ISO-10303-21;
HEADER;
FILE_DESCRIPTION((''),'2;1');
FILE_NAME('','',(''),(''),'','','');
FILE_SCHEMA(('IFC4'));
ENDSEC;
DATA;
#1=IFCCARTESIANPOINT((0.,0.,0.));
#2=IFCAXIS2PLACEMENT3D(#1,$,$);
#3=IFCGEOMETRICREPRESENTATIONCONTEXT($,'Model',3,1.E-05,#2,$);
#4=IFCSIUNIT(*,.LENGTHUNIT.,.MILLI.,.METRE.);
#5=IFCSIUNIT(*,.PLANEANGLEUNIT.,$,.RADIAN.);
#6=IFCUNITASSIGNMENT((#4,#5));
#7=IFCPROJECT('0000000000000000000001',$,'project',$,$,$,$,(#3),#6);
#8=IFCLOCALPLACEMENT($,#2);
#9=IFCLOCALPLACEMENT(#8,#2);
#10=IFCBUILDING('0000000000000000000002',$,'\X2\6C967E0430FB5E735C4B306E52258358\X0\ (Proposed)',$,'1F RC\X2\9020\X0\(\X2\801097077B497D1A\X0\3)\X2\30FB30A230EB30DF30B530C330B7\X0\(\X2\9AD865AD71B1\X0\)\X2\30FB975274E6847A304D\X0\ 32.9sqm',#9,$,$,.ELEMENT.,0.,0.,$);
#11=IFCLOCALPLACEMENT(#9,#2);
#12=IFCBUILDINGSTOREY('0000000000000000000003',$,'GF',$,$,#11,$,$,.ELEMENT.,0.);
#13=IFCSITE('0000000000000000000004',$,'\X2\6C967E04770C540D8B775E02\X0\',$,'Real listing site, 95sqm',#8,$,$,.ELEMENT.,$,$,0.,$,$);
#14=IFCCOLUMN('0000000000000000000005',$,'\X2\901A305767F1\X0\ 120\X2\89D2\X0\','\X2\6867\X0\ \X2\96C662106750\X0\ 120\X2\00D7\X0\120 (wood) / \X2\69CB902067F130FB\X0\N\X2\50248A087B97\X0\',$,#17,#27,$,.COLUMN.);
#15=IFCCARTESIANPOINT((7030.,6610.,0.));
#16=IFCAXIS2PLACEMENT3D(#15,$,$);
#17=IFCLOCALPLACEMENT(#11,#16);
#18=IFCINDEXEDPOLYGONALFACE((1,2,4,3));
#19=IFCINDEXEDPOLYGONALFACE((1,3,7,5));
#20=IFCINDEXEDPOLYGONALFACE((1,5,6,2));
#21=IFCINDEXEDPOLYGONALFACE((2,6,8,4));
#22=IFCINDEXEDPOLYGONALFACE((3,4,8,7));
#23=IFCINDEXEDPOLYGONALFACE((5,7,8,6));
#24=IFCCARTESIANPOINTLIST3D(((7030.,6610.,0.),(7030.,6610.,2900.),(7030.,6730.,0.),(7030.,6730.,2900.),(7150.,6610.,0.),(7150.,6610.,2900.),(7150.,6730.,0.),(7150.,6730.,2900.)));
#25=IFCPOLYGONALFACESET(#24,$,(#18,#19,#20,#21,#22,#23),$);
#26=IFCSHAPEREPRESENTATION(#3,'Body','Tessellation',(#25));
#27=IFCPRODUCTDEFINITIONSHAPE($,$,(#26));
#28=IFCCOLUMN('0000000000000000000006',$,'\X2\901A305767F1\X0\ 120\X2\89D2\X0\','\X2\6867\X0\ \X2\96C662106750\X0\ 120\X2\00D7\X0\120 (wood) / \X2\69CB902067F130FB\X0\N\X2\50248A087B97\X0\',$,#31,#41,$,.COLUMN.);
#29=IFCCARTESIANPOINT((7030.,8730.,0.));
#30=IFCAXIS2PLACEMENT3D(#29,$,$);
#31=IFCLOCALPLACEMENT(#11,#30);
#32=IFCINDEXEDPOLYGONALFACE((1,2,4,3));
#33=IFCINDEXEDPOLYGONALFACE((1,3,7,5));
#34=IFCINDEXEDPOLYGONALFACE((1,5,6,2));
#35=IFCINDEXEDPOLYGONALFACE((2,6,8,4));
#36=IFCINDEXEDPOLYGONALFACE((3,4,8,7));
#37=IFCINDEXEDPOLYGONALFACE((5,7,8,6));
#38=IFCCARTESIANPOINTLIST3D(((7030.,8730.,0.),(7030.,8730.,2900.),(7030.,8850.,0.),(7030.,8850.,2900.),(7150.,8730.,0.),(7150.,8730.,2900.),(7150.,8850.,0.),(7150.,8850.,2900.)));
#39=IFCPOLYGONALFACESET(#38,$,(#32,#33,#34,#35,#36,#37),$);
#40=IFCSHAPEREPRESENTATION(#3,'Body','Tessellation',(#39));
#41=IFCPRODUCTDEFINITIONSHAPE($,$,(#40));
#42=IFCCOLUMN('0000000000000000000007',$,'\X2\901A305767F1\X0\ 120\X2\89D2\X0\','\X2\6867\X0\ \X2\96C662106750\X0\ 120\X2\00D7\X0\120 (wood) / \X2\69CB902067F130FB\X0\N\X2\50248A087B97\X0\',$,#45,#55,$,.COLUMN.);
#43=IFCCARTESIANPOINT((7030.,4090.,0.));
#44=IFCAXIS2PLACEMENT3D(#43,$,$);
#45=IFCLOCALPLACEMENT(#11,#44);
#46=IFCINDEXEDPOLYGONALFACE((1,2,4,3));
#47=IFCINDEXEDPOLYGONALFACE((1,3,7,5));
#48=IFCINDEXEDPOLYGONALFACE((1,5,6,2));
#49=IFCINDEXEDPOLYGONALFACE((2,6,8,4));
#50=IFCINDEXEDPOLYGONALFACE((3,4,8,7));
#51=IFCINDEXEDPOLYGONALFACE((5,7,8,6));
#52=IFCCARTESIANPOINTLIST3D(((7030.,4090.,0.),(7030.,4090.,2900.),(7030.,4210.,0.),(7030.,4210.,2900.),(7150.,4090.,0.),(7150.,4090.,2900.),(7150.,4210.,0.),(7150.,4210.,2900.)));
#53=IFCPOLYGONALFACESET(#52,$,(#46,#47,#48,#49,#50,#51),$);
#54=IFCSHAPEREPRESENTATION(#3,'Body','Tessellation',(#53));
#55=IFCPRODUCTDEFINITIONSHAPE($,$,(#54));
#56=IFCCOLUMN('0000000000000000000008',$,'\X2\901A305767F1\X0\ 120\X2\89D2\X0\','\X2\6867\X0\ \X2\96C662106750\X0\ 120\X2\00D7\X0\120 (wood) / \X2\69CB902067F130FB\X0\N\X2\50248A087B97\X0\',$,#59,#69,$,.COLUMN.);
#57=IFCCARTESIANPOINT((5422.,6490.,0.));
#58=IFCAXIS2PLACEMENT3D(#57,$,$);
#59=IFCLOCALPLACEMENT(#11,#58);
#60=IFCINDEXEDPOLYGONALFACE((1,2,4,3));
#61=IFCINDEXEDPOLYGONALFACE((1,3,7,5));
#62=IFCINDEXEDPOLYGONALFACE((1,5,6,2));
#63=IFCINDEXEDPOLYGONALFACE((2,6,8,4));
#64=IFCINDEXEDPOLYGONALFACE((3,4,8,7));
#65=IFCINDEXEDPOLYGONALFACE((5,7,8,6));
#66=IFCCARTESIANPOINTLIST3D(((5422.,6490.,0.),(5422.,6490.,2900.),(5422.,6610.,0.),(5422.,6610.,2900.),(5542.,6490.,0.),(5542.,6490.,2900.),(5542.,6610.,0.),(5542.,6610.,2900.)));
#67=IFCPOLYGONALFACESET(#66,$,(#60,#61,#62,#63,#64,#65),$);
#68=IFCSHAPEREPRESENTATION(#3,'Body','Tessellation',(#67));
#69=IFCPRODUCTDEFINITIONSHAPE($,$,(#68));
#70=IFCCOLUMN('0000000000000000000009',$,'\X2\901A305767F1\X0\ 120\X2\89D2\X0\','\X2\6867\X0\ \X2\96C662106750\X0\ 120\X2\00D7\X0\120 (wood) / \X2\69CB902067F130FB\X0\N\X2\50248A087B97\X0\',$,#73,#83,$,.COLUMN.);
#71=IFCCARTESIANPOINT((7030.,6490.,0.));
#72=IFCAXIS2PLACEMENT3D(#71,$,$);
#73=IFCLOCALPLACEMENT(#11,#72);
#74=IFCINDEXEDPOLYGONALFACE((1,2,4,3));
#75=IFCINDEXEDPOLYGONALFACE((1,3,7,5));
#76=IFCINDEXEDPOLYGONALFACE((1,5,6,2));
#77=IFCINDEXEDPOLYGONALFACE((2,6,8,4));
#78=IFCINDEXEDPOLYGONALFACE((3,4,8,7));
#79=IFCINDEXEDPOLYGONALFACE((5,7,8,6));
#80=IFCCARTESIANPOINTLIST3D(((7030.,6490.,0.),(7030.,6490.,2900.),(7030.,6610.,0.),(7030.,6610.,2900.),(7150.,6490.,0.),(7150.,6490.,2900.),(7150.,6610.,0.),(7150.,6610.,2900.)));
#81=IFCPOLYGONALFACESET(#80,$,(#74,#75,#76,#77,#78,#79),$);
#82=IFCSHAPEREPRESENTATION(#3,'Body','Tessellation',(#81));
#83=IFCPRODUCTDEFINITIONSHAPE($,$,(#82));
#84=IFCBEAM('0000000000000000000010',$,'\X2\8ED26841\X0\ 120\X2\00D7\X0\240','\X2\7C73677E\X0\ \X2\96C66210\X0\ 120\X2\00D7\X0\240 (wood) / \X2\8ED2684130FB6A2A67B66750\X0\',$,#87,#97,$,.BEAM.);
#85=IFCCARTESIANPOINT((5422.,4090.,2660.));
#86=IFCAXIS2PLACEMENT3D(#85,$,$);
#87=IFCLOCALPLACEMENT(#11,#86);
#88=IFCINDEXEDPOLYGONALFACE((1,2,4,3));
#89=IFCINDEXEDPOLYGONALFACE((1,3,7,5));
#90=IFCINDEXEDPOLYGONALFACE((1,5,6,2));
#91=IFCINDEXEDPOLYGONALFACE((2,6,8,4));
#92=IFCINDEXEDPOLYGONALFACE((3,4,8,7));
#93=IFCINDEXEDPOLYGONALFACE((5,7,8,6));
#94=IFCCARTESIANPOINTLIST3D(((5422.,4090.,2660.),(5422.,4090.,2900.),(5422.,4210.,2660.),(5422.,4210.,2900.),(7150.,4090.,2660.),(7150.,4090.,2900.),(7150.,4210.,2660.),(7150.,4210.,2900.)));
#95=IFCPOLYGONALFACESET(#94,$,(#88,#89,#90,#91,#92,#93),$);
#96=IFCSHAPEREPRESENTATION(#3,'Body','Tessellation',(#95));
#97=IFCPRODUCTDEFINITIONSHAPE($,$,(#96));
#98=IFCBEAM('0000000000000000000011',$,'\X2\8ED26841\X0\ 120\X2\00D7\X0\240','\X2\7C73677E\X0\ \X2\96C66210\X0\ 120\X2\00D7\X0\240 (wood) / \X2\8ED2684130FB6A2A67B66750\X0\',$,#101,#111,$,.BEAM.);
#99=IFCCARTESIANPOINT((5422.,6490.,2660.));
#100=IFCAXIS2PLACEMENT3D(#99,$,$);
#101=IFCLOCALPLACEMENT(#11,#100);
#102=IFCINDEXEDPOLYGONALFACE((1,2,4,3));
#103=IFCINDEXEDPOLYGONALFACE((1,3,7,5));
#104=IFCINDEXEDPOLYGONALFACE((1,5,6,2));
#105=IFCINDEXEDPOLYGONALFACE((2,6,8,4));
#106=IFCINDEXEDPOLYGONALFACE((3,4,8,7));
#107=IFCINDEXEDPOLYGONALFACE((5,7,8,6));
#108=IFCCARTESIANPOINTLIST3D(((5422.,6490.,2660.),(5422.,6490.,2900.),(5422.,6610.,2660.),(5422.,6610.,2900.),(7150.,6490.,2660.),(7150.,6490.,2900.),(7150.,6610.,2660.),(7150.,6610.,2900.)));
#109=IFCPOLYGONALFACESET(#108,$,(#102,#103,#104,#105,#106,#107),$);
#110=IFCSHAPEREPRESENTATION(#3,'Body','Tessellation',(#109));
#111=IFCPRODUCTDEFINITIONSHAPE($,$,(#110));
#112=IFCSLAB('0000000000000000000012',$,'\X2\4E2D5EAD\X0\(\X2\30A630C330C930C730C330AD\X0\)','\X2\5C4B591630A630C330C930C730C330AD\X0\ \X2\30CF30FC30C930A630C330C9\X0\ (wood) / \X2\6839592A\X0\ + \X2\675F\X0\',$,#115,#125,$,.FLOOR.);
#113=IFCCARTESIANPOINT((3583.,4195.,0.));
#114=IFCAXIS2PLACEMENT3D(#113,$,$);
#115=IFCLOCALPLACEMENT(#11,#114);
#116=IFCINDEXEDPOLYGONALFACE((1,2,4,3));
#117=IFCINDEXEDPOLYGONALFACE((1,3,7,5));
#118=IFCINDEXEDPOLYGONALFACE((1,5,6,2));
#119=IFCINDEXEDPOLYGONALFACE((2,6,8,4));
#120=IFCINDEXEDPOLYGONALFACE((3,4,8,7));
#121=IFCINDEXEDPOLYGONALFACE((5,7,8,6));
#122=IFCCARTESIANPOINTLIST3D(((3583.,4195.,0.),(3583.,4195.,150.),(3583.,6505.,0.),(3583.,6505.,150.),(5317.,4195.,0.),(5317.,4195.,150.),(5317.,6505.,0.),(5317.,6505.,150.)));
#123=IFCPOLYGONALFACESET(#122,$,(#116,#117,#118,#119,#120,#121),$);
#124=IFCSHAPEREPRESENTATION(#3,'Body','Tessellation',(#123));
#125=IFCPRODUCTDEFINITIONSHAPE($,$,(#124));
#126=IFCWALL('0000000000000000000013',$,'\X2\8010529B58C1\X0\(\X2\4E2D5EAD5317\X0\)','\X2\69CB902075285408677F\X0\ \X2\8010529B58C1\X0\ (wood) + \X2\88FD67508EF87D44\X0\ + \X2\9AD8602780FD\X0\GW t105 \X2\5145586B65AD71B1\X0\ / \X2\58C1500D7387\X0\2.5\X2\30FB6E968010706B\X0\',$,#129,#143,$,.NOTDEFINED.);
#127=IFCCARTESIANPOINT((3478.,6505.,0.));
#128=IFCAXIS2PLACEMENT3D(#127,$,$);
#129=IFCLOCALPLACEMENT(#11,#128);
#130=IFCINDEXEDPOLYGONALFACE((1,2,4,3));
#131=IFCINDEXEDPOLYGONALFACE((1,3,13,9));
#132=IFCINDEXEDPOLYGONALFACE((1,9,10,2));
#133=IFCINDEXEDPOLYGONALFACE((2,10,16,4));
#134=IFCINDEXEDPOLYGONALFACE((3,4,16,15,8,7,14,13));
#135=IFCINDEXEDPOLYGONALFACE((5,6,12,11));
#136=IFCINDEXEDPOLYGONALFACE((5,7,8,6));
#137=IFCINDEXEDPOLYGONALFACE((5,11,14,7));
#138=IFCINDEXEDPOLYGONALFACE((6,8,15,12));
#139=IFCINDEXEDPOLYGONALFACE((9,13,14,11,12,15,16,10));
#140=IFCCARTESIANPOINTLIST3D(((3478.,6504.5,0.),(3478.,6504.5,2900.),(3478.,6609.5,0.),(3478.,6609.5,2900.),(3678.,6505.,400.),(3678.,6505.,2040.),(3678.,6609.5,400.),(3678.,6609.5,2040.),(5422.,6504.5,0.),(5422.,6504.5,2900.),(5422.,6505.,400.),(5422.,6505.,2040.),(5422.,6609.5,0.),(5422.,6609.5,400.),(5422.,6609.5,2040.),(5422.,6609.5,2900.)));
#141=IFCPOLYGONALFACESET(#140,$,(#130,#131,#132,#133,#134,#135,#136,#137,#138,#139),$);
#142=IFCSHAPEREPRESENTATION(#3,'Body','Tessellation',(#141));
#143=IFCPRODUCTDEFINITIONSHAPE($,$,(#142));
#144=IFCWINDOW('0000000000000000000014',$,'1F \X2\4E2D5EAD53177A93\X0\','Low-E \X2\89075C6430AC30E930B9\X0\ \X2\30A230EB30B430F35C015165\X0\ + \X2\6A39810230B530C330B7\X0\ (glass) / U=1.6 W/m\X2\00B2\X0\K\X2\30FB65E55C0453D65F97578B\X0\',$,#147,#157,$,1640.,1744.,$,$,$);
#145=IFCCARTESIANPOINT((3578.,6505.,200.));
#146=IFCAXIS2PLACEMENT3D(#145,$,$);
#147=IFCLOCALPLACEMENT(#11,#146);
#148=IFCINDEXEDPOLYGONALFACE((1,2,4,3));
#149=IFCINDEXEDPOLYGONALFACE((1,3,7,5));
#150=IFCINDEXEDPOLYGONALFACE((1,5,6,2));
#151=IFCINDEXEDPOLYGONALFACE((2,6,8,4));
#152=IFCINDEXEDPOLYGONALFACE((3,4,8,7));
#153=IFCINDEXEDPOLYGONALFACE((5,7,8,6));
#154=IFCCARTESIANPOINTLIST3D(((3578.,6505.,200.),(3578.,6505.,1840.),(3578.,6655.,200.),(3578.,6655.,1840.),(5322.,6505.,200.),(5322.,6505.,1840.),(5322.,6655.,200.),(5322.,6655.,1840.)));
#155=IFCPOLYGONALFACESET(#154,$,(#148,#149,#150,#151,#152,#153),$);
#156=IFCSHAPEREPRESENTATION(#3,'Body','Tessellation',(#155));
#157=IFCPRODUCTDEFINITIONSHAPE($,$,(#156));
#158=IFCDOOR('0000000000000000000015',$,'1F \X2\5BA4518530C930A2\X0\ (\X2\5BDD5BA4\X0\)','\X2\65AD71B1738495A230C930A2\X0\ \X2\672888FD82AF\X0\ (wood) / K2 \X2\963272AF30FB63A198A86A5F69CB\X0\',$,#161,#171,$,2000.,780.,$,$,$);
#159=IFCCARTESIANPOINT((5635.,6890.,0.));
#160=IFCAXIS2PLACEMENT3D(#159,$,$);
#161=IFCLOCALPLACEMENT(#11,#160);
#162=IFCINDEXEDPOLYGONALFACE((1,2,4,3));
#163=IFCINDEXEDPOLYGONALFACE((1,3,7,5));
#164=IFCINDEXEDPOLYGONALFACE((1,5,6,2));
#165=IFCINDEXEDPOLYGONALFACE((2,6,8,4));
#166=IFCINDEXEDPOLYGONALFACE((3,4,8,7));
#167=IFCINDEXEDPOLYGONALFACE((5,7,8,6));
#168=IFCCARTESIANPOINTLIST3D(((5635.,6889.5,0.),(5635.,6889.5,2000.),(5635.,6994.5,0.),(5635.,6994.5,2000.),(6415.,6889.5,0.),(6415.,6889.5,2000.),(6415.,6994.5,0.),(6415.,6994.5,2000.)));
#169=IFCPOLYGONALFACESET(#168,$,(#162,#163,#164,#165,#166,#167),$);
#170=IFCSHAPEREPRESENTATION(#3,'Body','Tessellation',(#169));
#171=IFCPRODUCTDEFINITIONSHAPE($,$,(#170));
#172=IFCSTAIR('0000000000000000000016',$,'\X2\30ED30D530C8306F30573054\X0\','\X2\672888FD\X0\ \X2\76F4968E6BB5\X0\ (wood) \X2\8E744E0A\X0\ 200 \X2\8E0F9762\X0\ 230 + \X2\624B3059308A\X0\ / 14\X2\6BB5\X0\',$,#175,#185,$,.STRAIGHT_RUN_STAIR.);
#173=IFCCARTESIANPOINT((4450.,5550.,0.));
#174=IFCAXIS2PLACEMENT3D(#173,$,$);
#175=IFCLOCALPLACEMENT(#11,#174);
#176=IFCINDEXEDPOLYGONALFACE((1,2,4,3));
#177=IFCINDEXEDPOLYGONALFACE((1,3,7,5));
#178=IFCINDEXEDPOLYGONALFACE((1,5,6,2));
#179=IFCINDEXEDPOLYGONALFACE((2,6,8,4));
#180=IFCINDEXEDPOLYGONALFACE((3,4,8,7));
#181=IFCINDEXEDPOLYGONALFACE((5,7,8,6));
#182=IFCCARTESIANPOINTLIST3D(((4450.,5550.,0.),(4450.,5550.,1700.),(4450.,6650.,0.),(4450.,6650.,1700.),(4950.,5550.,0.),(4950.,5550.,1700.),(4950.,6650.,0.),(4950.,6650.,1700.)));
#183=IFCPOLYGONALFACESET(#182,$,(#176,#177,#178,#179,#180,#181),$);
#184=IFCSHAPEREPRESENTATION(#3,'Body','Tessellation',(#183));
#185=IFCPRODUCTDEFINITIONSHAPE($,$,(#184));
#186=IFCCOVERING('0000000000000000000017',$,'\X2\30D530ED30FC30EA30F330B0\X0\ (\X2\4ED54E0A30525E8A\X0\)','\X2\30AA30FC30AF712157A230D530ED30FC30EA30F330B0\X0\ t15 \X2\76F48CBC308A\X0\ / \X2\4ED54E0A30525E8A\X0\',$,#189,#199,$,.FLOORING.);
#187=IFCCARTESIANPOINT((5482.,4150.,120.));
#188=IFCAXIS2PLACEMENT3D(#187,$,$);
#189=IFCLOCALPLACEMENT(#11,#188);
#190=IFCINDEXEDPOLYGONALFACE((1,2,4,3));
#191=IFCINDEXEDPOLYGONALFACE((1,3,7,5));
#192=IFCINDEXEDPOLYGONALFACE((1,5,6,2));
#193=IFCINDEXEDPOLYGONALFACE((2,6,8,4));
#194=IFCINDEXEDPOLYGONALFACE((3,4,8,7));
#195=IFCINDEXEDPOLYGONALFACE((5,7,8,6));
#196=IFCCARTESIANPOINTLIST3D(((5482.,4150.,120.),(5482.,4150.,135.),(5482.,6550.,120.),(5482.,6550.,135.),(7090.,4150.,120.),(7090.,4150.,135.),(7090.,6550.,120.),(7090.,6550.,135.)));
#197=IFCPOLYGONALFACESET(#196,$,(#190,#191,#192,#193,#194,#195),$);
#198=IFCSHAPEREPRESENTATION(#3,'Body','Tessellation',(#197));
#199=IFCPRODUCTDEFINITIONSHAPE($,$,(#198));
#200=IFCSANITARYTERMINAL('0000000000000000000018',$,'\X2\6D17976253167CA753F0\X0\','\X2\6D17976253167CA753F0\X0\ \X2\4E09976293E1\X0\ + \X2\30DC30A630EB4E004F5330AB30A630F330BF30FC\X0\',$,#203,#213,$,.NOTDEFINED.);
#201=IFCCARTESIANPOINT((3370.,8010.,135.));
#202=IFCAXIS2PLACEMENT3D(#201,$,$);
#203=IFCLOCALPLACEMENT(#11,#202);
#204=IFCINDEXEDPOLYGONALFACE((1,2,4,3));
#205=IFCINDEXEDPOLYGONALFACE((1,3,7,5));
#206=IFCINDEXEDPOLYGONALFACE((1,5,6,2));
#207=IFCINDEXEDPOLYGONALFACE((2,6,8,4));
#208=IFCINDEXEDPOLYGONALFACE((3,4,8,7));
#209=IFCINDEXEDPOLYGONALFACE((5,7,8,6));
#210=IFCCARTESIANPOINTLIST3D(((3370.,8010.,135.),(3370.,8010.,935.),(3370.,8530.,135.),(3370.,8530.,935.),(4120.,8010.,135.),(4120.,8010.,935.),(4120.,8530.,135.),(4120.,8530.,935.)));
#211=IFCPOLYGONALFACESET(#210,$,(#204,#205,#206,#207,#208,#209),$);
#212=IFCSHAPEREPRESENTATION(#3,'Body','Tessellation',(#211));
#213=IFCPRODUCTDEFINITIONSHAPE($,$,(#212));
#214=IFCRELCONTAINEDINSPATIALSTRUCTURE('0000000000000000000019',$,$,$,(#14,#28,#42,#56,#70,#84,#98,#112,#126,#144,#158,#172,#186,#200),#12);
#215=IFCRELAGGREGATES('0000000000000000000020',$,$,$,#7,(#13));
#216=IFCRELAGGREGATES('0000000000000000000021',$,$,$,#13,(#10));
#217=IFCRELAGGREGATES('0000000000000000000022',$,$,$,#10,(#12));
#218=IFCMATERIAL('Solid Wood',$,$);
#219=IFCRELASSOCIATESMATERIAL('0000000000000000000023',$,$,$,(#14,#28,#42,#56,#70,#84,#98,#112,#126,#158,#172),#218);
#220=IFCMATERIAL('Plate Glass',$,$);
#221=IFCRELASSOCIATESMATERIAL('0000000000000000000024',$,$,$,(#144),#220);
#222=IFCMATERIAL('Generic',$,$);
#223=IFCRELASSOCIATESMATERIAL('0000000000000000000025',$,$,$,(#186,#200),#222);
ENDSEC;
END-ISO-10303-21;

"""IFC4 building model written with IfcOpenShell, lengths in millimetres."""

from ifc_helpers import new_model, si_unit, frame, frame_2d, origin, place, context, project, spatial, rectangle, extrude, material, element, fill, save


model = new_model("IFC4")

# Units and contexts
model_context = context("Model", 3, precision=1e-05, world=origin())
ifc_project = project(units=[si_unit("LENGTHUNIT", "METRE", prefix="MILLI"), si_unit("PLANEANGLEUNIT", "RADIAN")], contexts=[model_context])

# Site, building, storey
site_placement = place(None, origin())
site = spatial("IfcSite", under=ifc_project, at=site_placement, Name="沖縄県名護市", ObjectType="Real listing site, 95sqm", CompositionType="ELEMENT", RefElevation=0.0)
building_placement = place(site_placement, origin())
building = spatial("IfcBuilding", under=site, at=building_placement, Name="沖縄・平屋の別荘 (Proposed)", ObjectType="1F RC造(耐震等級3)・アルミサッシ(高断熱)・青瓦葺き 32.9sqm", CompositionType="ELEMENT", ElevationOfRefHeight=0.0, ElevationOfTerrain=0.0)
storey_placement = place(building_placement, origin())
storey = spatial("IfcBuildingStorey", under=building, at=storey_placement, Name="GF", CompositionType="ELEMENT", Elevation=0.0)

# Columns
ifc_material_1 = material(Name="Solid Wood")
column_1_placement = place(storey_placement, frame((7030.0, 6610.0, 0.0)))
element("IfcColumn", 1, at=column_1_placement, inside=storey, material=ifc_material_1, Name="通し柱 120角", Description="桧 集成材 120×120 (wood) / 構造柱・N値計算", PredefinedType="COLUMN", context=model_context, shape_type="SweptSolid", body=[
    extrude(rectangle(XDim=120.0, YDim=120.0, at=frame_2d((60.0, 60.0))), frame((7030.0, 6610.0, 0.0)), (0.0, 0.0, 1.0), 2900.0),
])
column_2_placement = place(storey_placement, frame((7030.0, 8730.0, 0.0)))
element("IfcColumn", 2, at=column_2_placement, inside=storey, material=ifc_material_1, Name="通し柱 120角", Description="桧 集成材 120×120 (wood) / 構造柱・N値計算", PredefinedType="COLUMN", context=model_context, shape_type="SweptSolid", body=[
    extrude(rectangle(XDim=120.0, YDim=120.0, at=frame_2d((60.0, 60.0))), frame((7030.0, 8730.0, 0.0)), (0.0, 0.0, 1.0), 2900.0),
])
column_3_placement = place(storey_placement, frame((7030.0, 4090.0, 0.0)))
element("IfcColumn", 3, at=column_3_placement, inside=storey, material=ifc_material_1, Name="通し柱 120角", Description="桧 集成材 120×120 (wood) / 構造柱・N値計算", PredefinedType="COLUMN", context=model_context, shape_type="SweptSolid", body=[
    extrude(rectangle(XDim=120.0, YDim=120.0, at=frame_2d((60.0, 60.0))), frame((7030.0, 4090.0, 0.0)), (0.0, 0.0, 1.0), 2900.0),
])
column_4_placement = place(storey_placement, frame((5422.0, 6490.0, 0.0)))
element("IfcColumn", 4, at=column_4_placement, inside=storey, material=ifc_material_1, Name="通し柱 120角", Description="桧 集成材 120×120 (wood) / 構造柱・N値計算", PredefinedType="COLUMN", context=model_context, shape_type="SweptSolid", body=[
    extrude(rectangle(XDim=120.0, YDim=120.0, at=frame_2d((60.0, 60.0))), frame((5422.0, 6490.0, 0.0)), (0.0, 0.0, 1.0), 2900.0),
])
column_5_placement = place(storey_placement, frame((7030.0, 6490.0, 0.0)))
element("IfcColumn", 5, at=column_5_placement, inside=storey, material=ifc_material_1, Name="通し柱 120角", Description="桧 集成材 120×120 (wood) / 構造柱・N値計算", PredefinedType="COLUMN", context=model_context, shape_type="SweptSolid", body=[
    extrude(rectangle(XDim=120.0, YDim=120.0, at=frame_2d((60.0, 60.0))), frame((7030.0, 6490.0, 0.0)), (0.0, 0.0, 1.0), 2900.0),
])

# Beams
beam_1_placement = place(storey_placement, frame((5422.0, 4090.0, 2660.0)))
element("IfcBeam", 6, at=beam_1_placement, inside=storey, material=ifc_material_1, Name="軒桁 120×240", Description="米松 集成 120×240 (wood) / 軒桁・横架材", PredefinedType="BEAM", context=model_context, shape_type="SweptSolid", body=[
    extrude(rectangle(XDim=1728.0, YDim=120.0, at=frame_2d((864.0, 60.0))), frame((5422.0, 4090.0, 2660.0)), (0.0, 0.0, 1.0), 240.0),
])
beam_2_placement = place(storey_placement, frame((5422.0, 6490.0, 2660.0)))
element("IfcBeam", 7, at=beam_2_placement, inside=storey, material=ifc_material_1, Name="軒桁 120×240", Description="米松 集成 120×240 (wood) / 軒桁・横架材", PredefinedType="BEAM", context=model_context, shape_type="SweptSolid", body=[
    extrude(rectangle(XDim=1728.0, YDim=120.0, at=frame_2d((864.0, 60.0))), frame((5422.0, 6490.0, 2660.0)), (0.0, 0.0, 1.0), 240.0),
])

# Slab
slab_placement = place(storey_placement, frame((3583.0, 4195.0, 0.0)))
element("IfcSlab", 8, at=slab_placement, inside=storey, material=ifc_material_1, Name="中庭(ウッドデッキ)", Description="屋外ウッドデッキ ハードウッド (wood) / 根太 + 束", PredefinedType="FLOOR", context=model_context, shape_type="SweptSolid", body=[
    extrude(rectangle(XDim=1734.0, YDim=2310.0, at=frame_2d((867.0, 1155.0))), frame((3583.0, 4195.0, 0.0)), (0.0, 0.0, 1.0), 150.0),
])

# Wall, opening, window
wall_1_placement = place(storey_placement, frame((3478.0, 6505.0, 0.0)))
wall_1 = element("IfcWall", 9, at=wall_1_placement, inside=storey, material=ifc_material_1, Name="耐力壁(中庭北)", Description="構造用合板 耐力壁 (wood) + 製材軸組 + 高性能GW t105 充填断熱 / 壁倍率2.5・準耐火", PredefinedType="NOTDEFINED", context=model_context, shape_type="SweptSolid", body=[
    extrude(rectangle(XDim=1944.0, YDim=105.0, at=frame_2d((972.0, 52.0))), frame((3478.0, 6505.0, 0.0)), (0.0, 0.0, 1.0), 2900.0),
])
opening_placement = place(storey_placement, frame((3578.0, 6505.0, 200.0)))
opening = element("IfcOpeningElement", 10, at=opening_placement, cuts=wall_1, PredefinedType="NOTDEFINED", context=model_context, shape_type="SweptSolid", body=[
    extrude(rectangle(XDim=1744.0, YDim=150.0, at=frame_2d((872.0, 75.0))), frame((3578.0, 6505.0, 200.0)), (0.0, 0.0, 1.0), 1640.0),
])
ifc_material_2 = material(Name="Plate Glass")
window_placement = place(storey_placement, frame((3578.0, 6505.0, 200.0)))
window = element("IfcWindow", 11, at=window_placement, inside=storey, material=ifc_material_2, Name="1F 中庭北窓", Description="Low-E 複層ガラス アルゴン封入 + 樹脂サッシ (glass) / U=1.6 W/m²K・日射取得型", OverallHeight=1640.0, OverallWidth=1744.0, context=model_context, shape_type="SweptSolid", body=[
    extrude(rectangle(XDim=1744.0, YDim=150.0, at=frame_2d((872.0, 75.0))), frame((3578.0, 6505.0, 200.0)), (0.0, 0.0, 1.0), 1640.0),
])
fill(opening, window)

# Door
door_placement = place(storey_placement, frame((5635.0, 6890.0, 0.0)))
element("IfcDoor", 12, at=door_placement, inside=storey, material=ifc_material_1, Name="1F 室内ドア (寝室)", Description="断熱玄関ドア 木製芯 (wood) / K2 防犯・採風機構", OverallHeight=2000.0, OverallWidth=780.0, context=model_context, shape_type="SweptSolid", body=[
    extrude(rectangle(XDim=780.0, YDim=105.0, at=frame_2d((390.0, 52.0))), frame((5635.0, 6890.0, 0.0)), (0.0, 0.0, 1.0), 2000.0),
])

# Stair
stair_placement = place(storey_placement, frame((4450.0, 5550.0, 0.0)))
element("IfcStair", 13, at=stair_placement, inside=storey, material=ifc_material_1, Name="ロフトはしご", Description="木製 直階段 (wood) 蹴上 200 踏面 230 + 手すり / 14段", PredefinedType="STRAIGHT_RUN_STAIR", context=model_context, shape_type="SweptSolid", body=[
    extrude(rectangle(XDim=500.0, YDim=1100.0, at=frame_2d((250.0, 550.0))), frame((4450.0, 5550.0, 0.0)), (0.0, 0.0, 1.0), 1700.0),
])

# Covering
ifc_material_3 = material(Name="Generic")
covering_placement = place(storey_placement, frame((5482.0, 4150.0, 120.0)))
element("IfcCovering", 14, at=covering_placement, inside=storey, material=ifc_material_3, Name="フローリング (仕上げ床)", Description="オーク無垢フローリング t15 直貼り / 仕上げ床", PredefinedType="FLOORING", context=model_context, shape_type="SweptSolid", body=[
    extrude(rectangle(XDim=1608.0, YDim=2400.0, at=frame_2d((804.0, 1200.0))), frame((5482.0, 4150.0, 120.0)), (0.0, 0.0, 1.0), 15.0),
])

# Sanitary terminal
sanitary_terminal_1_placement = place(storey_placement, frame((3370.0, 8010.0, 135.0)))
element("IfcSanitaryTerminal", 15, at=sanitary_terminal_1_placement, inside=storey, material=ifc_material_3, Name="洗面化粧台", Description="洗面化粧台 三面鏡 + ボウル一体カウンター", PredefinedType="NOTDEFINED", context=model_context, shape_type="SweptSolid", body=[
    extrude(rectangle(XDim=750.0, YDim=520.0, at=frame_2d((375.0, 260.0))), frame((3370.0, 8010.0, 135.0)), (0.0, 0.0, 1.0), 800.0),
])

save(model, "model.ifc")
